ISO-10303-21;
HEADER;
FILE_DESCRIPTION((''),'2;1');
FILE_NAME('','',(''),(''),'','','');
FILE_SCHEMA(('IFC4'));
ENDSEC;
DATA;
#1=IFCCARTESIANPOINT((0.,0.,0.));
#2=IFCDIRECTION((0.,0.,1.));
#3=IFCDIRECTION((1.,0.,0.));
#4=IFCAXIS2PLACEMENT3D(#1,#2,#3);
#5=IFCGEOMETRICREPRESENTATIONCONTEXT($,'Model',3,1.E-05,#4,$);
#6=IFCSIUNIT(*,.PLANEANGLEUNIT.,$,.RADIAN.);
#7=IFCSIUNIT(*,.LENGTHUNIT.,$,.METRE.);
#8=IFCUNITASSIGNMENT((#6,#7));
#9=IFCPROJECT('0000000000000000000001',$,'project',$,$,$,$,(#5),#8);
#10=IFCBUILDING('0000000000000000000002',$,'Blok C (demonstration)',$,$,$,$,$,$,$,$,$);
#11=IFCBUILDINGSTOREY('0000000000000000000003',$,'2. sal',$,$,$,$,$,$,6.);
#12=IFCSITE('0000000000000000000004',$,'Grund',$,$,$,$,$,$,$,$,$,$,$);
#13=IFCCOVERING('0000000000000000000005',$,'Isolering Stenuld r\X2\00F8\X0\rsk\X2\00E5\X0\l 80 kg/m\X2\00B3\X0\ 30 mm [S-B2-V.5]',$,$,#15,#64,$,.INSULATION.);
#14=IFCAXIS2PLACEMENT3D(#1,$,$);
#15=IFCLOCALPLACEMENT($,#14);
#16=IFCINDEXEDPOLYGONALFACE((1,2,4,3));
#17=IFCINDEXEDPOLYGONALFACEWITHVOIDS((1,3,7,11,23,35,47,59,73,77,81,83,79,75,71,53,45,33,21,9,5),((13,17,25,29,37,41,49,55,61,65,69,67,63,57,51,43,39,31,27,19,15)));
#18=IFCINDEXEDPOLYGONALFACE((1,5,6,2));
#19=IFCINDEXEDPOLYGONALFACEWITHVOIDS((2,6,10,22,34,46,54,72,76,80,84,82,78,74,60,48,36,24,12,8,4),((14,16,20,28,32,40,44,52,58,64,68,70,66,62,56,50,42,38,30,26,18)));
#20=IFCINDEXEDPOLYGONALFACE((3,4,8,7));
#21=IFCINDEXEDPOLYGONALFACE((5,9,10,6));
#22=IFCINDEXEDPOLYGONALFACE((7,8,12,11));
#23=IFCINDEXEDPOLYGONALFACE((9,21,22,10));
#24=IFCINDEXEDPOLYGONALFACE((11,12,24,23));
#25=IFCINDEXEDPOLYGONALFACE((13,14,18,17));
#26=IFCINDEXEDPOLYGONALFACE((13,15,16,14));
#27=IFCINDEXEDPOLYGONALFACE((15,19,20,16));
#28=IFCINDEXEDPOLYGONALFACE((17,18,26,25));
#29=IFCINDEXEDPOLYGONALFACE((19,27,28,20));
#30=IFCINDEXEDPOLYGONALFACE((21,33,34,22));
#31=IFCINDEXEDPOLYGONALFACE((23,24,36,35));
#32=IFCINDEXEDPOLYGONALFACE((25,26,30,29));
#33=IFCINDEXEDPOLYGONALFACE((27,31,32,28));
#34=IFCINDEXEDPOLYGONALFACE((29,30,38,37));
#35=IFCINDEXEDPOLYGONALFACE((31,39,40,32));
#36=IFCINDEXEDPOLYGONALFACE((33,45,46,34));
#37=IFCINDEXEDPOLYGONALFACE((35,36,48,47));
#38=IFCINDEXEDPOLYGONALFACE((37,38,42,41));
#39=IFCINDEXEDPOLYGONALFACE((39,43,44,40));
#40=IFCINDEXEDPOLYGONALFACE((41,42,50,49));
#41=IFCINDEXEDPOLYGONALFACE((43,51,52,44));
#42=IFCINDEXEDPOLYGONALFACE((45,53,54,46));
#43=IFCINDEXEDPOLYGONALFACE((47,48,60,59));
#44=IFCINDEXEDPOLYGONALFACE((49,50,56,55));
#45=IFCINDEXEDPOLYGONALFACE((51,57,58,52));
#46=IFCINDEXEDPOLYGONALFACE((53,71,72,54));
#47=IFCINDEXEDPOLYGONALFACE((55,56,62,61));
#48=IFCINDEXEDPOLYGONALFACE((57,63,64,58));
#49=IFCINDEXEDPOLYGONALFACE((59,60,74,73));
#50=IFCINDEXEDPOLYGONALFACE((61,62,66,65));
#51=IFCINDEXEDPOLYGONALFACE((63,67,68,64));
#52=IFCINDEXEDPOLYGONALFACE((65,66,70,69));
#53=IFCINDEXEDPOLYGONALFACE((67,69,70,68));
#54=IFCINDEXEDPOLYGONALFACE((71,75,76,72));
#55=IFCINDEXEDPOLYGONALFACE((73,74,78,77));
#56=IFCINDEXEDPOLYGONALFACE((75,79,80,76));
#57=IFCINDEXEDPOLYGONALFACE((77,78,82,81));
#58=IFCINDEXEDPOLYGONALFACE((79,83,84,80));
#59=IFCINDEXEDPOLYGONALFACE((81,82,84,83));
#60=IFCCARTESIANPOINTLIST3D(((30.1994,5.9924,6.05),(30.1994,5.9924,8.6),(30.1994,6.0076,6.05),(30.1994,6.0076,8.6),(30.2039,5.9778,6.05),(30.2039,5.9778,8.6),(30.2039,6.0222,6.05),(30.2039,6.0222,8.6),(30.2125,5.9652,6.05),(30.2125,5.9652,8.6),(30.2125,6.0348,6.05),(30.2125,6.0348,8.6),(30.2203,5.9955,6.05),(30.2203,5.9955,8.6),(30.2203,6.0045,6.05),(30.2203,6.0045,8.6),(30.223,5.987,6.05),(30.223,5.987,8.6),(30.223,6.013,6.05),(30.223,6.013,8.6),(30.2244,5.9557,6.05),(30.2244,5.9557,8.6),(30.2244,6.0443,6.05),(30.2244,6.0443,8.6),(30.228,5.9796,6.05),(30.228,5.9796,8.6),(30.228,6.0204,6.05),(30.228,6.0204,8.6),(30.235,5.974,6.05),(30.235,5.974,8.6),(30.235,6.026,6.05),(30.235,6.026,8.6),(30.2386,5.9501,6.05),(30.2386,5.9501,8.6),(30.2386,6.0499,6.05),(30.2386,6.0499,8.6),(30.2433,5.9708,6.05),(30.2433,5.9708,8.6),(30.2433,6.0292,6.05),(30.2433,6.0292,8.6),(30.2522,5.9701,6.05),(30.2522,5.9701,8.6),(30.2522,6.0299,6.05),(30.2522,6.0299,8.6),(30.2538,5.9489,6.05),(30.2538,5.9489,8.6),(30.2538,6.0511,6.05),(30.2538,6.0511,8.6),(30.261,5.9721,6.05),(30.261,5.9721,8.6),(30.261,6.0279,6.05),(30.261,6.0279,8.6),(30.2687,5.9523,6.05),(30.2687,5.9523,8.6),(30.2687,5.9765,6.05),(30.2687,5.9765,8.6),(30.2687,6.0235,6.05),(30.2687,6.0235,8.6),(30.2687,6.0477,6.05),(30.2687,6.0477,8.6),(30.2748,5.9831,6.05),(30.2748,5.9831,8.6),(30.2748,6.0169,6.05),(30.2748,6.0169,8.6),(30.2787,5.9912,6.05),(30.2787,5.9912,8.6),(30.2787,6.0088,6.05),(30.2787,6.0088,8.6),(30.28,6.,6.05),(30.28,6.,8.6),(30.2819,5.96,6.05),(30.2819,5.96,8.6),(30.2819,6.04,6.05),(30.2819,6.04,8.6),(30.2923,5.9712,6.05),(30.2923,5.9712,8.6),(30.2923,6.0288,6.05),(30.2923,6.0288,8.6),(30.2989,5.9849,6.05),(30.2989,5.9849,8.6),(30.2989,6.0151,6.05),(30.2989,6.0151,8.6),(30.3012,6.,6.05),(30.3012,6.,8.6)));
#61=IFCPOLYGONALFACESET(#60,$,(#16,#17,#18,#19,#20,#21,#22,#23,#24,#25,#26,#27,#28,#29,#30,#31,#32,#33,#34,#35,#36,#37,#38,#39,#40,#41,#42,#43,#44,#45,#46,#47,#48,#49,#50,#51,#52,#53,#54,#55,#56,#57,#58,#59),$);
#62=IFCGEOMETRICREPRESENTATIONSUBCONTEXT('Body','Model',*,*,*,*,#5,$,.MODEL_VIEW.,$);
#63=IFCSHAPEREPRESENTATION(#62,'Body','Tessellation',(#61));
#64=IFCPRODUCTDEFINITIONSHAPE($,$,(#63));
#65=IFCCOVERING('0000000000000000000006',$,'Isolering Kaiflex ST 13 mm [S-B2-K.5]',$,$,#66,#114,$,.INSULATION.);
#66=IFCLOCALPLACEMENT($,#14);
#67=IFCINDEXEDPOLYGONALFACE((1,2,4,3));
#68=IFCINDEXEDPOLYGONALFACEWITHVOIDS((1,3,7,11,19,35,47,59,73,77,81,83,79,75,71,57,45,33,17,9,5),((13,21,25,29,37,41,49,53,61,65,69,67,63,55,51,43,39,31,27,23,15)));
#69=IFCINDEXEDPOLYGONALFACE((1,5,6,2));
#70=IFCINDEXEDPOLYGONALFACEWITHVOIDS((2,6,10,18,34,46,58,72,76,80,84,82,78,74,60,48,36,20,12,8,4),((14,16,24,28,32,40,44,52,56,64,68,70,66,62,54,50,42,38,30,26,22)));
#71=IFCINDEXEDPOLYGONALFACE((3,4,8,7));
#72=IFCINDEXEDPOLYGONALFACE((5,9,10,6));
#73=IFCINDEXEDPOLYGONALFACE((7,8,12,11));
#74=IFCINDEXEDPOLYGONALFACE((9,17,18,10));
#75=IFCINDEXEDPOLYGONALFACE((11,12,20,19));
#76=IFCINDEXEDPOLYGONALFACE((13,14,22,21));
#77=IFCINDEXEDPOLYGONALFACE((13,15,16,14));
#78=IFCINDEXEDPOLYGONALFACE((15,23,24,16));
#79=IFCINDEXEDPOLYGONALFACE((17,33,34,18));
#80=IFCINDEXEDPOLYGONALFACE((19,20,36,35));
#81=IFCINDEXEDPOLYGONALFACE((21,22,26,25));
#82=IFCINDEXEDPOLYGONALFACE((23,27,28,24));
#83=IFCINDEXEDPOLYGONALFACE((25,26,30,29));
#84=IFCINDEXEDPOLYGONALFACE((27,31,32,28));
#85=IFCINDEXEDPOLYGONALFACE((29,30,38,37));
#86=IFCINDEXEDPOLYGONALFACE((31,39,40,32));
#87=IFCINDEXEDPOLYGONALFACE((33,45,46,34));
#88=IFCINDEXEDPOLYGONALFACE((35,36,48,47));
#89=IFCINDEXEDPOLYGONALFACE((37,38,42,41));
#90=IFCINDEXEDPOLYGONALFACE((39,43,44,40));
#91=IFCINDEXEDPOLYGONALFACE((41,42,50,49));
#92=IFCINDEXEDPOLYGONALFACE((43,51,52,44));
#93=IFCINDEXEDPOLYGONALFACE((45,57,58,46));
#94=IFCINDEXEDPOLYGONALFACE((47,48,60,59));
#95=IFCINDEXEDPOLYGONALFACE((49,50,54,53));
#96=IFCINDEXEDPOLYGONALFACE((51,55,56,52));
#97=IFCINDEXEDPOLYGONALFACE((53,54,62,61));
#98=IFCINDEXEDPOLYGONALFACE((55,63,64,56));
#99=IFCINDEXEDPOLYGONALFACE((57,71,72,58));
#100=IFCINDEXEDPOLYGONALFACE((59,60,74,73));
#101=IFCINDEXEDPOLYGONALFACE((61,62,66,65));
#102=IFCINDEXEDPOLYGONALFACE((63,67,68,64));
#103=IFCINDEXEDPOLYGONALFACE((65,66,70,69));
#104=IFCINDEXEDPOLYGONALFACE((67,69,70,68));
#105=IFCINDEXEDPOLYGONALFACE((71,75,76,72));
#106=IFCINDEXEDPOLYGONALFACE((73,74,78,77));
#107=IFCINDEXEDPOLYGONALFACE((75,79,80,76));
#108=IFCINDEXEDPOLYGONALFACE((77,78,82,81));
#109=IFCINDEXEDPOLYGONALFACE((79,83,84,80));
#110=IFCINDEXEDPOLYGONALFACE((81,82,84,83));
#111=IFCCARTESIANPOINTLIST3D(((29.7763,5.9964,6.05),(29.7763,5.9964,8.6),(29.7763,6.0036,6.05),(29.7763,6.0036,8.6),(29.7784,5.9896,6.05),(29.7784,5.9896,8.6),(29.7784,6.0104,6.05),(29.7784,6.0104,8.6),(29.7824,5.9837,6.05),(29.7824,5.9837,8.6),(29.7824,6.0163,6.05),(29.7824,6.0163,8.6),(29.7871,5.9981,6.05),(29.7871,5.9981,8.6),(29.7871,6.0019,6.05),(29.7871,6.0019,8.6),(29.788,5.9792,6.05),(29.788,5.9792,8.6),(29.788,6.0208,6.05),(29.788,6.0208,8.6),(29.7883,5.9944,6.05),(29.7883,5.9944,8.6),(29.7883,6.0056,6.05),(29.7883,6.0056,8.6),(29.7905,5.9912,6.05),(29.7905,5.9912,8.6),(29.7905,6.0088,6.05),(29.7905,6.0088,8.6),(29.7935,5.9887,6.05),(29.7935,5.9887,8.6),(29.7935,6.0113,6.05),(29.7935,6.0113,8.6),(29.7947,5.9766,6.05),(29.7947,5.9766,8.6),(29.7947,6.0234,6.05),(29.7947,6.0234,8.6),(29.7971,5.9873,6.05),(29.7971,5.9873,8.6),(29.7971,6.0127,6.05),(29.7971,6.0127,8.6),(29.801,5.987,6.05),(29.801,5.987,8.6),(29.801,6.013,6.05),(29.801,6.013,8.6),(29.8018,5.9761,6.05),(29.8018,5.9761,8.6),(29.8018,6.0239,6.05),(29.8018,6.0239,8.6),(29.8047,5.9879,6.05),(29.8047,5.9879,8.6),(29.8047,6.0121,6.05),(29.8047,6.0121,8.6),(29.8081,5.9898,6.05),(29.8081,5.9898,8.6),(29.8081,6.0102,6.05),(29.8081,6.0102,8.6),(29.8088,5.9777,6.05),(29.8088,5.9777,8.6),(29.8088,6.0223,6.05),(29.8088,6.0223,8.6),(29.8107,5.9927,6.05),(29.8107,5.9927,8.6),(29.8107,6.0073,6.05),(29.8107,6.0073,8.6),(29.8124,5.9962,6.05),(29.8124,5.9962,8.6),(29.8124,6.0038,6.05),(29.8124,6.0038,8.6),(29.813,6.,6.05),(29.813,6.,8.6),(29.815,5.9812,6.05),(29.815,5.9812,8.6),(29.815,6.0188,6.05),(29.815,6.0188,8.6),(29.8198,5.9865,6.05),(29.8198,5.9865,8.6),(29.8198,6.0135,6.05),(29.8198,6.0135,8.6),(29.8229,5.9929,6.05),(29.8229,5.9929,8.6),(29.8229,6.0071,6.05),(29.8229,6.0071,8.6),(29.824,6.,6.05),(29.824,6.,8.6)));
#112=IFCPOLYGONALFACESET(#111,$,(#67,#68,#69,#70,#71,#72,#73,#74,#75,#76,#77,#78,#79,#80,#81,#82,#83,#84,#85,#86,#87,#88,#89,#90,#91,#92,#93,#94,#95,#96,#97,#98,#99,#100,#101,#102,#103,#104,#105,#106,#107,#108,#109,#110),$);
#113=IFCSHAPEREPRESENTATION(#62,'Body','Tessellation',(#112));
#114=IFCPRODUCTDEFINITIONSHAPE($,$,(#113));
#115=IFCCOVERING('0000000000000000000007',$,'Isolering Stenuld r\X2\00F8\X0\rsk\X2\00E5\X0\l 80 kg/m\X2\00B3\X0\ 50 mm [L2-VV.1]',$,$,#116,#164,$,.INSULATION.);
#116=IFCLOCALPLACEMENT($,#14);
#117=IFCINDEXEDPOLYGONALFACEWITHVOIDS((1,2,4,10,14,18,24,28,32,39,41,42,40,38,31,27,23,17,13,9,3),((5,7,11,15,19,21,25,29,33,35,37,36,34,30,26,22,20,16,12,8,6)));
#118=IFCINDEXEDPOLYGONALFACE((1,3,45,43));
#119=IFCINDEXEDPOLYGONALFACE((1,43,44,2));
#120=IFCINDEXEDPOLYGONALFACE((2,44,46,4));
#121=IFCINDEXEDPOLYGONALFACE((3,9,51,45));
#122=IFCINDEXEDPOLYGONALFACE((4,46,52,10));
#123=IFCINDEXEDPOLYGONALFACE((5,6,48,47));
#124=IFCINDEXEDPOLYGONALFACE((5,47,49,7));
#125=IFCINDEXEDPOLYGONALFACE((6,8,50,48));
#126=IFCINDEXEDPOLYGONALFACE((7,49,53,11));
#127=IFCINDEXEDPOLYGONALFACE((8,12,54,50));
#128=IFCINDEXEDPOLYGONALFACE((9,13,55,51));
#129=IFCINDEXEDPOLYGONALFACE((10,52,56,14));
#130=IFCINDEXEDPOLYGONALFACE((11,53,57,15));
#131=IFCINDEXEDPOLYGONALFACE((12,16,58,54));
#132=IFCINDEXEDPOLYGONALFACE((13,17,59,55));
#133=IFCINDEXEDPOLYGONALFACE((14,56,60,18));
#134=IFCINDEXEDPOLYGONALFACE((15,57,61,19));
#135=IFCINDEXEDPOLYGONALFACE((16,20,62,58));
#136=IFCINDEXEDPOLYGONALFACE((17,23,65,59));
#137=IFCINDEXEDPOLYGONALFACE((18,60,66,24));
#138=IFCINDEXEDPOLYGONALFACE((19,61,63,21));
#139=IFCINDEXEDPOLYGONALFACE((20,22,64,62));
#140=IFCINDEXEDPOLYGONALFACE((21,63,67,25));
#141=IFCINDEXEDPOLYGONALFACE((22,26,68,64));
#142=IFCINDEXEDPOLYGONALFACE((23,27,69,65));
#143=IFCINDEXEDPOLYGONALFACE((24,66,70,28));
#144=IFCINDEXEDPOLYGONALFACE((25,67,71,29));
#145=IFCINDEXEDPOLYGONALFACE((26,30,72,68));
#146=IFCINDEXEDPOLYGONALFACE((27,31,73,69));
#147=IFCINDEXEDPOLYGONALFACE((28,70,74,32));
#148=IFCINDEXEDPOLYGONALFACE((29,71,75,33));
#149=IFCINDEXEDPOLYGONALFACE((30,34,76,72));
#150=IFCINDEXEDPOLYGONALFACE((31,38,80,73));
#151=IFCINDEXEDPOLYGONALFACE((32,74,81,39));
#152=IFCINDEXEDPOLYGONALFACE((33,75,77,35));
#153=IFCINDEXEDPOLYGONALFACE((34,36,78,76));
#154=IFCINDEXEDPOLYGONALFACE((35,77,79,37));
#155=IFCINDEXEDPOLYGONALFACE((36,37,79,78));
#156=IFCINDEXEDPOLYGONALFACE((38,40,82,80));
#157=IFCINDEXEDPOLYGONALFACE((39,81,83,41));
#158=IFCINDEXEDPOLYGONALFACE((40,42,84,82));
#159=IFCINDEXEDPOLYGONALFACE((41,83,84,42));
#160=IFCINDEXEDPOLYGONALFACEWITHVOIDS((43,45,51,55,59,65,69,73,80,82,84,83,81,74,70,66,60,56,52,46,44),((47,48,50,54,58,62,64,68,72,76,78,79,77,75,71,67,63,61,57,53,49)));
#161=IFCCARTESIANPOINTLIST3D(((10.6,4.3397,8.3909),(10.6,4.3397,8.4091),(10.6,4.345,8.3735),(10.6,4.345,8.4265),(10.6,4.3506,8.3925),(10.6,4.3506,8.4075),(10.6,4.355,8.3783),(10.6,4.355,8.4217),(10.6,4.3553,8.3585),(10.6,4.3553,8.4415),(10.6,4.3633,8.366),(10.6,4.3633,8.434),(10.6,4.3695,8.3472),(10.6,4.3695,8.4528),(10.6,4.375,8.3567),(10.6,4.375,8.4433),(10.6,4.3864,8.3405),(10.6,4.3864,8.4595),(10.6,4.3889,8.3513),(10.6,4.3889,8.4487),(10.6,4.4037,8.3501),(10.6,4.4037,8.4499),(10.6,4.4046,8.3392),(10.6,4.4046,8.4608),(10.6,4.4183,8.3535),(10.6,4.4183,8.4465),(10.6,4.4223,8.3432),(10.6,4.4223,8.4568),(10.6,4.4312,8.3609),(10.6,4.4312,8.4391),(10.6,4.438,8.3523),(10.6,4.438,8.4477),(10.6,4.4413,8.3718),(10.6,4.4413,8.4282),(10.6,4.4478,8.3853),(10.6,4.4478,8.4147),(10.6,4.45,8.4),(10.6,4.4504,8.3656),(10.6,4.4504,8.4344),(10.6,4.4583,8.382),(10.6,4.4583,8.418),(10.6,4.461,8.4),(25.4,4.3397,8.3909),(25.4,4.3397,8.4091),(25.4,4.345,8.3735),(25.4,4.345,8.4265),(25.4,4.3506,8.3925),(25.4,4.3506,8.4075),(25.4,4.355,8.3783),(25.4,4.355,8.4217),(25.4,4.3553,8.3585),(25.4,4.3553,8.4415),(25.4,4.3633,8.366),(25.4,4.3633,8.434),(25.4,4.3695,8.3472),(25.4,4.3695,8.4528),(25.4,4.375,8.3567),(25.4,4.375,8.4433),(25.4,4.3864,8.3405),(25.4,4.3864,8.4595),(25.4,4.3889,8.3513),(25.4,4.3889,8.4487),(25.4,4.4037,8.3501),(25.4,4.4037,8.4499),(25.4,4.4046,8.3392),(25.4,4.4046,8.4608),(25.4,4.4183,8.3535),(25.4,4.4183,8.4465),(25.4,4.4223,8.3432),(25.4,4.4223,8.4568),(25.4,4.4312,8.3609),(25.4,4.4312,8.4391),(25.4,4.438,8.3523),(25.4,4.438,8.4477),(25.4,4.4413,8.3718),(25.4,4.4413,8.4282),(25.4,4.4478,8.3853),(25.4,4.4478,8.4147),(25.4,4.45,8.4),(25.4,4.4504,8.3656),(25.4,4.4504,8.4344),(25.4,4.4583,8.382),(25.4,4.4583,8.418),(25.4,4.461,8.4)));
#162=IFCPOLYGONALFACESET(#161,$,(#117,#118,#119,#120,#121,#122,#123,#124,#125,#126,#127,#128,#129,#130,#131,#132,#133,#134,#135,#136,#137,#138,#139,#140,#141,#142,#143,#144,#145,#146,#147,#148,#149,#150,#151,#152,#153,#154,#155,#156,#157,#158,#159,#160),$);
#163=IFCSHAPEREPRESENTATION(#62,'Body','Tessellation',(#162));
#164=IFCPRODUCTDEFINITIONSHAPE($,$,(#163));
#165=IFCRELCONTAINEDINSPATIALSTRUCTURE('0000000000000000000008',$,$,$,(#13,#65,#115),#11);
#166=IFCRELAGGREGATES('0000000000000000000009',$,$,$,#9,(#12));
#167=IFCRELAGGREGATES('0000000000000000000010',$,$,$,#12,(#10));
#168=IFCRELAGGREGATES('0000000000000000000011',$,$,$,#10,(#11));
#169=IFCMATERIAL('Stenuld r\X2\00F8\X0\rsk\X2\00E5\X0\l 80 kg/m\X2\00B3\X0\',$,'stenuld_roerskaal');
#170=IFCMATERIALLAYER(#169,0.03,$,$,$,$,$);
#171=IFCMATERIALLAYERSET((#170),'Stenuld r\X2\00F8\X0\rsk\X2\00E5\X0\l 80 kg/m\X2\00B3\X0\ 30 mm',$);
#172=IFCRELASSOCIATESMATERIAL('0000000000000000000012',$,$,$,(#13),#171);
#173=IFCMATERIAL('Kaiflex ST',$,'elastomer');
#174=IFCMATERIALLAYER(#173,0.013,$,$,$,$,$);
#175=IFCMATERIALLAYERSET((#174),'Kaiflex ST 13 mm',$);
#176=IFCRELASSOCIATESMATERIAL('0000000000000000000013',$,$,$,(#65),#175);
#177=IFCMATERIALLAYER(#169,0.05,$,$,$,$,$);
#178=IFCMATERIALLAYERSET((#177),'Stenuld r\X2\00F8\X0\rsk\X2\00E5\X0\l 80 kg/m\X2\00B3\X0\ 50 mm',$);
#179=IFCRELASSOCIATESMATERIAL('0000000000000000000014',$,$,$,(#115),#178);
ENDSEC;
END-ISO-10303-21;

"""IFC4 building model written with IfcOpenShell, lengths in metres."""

from ifc_helpers import new_model, si_unit, frame, origin_with_axes, place, context, subcontext, project, spatial, hollow_circle, extrude, material, layer, layer_set, element, save


model = new_model("IFC4")

# Units and contexts
model_context = context("Model", 3, precision=1e-05, world=origin_with_axes())
body_context = subcontext(model_context, "Body", "Model", "MODEL_VIEW")
ifc_project = project(units=[si_unit("PLANEANGLEUNIT", "RADIAN"), si_unit("LENGTHUNIT", "METRE")], contexts=[model_context])

# Site, building, storey
site = spatial("IfcSite", under=ifc_project, Name="Grund")
building = spatial("IfcBuilding", under=site, Name="Blok C (demonstration)")
storey = spatial("IfcBuildingStorey", under=building, Name="2. sal", Elevation=6.0)

# Coverings
ifc_material_1 = material(Name="Stenuld rørskål 80 kg/m³", Category="stenuld_roerskaal")
ifc_material_2 = material(Name="Kaiflex ST", Category="elastomer")
ifc_layer_1 = layer(ifc_material_1, 0.03)
ifc_layer_set_1 = layer_set([ifc_layer_1], Name="Stenuld rørskål 80 kg/m³ 30 mm")
covering_1_placement = place(None, origin_with_axes())
element("IfcCovering", 1, at=covering_1_placement, inside=storey, material=ifc_layer_set_1, Name="Isolering Stenuld rørskål 80 kg/m³ 30 mm [S-B2-V.5]", PredefinedType="INSULATION", context=body_context, shape_type="SweptSolid", body=[
    extrude(hollow_circle(Radius=0.0512, WallThickness=0.0212), frame((30.25, 6.0, 6.05), z_axis=(0.0, 0.0, 1.0), x_axis=(1.0, 0.0, 0.0)), (0.0, 0.0, 1.0), 2.55),
])
ifc_layer_2 = layer(ifc_material_2, 0.013)
ifc_layer_set_2 = layer_set([ifc_layer_2], Name="Kaiflex ST 13 mm")
covering_2_placement = place(None, origin_with_axes())
element("IfcCovering", 2, at=covering_2_placement, inside=storey, material=ifc_layer_set_2, Name="Isolering Kaiflex ST 13 mm [S-B2-K.5]", PredefinedType="INSULATION", context=body_context, shape_type="SweptSolid", body=[
    extrude(hollow_circle(Radius=0.024, WallThickness=0.011), frame((29.8, 6.0, 6.05), z_axis=(0.0, 0.0, 1.0), x_axis=(1.0, 0.0, 0.0)), (0.0, 0.0, 1.0), 2.55),
])
ifc_layer_3 = layer(ifc_material_1, 0.05)
ifc_layer_set_3 = layer_set([ifc_layer_3], Name="Stenuld rørskål 80 kg/m³ 50 mm")
covering_3_placement = place(None, origin_with_axes())
element("IfcCovering", 3, at=covering_3_placement, inside=storey, material=ifc_layer_set_3, Name="Isolering Stenuld rørskål 80 kg/m³ 50 mm [L2-VV.1]", PredefinedType="INSULATION", context=body_context, shape_type="SweptSolid", body=[
    extrude(hollow_circle(Radius=0.061, WallThickness=0.011), frame((10.6, 4.4, 8.4), z_axis=(1.0, 0.0, 0.0), x_axis=(0.0, 1.0, 0.0)), (0.0, 0.0, 1.0), 14.8),
])

save(model, "model.ifc")
